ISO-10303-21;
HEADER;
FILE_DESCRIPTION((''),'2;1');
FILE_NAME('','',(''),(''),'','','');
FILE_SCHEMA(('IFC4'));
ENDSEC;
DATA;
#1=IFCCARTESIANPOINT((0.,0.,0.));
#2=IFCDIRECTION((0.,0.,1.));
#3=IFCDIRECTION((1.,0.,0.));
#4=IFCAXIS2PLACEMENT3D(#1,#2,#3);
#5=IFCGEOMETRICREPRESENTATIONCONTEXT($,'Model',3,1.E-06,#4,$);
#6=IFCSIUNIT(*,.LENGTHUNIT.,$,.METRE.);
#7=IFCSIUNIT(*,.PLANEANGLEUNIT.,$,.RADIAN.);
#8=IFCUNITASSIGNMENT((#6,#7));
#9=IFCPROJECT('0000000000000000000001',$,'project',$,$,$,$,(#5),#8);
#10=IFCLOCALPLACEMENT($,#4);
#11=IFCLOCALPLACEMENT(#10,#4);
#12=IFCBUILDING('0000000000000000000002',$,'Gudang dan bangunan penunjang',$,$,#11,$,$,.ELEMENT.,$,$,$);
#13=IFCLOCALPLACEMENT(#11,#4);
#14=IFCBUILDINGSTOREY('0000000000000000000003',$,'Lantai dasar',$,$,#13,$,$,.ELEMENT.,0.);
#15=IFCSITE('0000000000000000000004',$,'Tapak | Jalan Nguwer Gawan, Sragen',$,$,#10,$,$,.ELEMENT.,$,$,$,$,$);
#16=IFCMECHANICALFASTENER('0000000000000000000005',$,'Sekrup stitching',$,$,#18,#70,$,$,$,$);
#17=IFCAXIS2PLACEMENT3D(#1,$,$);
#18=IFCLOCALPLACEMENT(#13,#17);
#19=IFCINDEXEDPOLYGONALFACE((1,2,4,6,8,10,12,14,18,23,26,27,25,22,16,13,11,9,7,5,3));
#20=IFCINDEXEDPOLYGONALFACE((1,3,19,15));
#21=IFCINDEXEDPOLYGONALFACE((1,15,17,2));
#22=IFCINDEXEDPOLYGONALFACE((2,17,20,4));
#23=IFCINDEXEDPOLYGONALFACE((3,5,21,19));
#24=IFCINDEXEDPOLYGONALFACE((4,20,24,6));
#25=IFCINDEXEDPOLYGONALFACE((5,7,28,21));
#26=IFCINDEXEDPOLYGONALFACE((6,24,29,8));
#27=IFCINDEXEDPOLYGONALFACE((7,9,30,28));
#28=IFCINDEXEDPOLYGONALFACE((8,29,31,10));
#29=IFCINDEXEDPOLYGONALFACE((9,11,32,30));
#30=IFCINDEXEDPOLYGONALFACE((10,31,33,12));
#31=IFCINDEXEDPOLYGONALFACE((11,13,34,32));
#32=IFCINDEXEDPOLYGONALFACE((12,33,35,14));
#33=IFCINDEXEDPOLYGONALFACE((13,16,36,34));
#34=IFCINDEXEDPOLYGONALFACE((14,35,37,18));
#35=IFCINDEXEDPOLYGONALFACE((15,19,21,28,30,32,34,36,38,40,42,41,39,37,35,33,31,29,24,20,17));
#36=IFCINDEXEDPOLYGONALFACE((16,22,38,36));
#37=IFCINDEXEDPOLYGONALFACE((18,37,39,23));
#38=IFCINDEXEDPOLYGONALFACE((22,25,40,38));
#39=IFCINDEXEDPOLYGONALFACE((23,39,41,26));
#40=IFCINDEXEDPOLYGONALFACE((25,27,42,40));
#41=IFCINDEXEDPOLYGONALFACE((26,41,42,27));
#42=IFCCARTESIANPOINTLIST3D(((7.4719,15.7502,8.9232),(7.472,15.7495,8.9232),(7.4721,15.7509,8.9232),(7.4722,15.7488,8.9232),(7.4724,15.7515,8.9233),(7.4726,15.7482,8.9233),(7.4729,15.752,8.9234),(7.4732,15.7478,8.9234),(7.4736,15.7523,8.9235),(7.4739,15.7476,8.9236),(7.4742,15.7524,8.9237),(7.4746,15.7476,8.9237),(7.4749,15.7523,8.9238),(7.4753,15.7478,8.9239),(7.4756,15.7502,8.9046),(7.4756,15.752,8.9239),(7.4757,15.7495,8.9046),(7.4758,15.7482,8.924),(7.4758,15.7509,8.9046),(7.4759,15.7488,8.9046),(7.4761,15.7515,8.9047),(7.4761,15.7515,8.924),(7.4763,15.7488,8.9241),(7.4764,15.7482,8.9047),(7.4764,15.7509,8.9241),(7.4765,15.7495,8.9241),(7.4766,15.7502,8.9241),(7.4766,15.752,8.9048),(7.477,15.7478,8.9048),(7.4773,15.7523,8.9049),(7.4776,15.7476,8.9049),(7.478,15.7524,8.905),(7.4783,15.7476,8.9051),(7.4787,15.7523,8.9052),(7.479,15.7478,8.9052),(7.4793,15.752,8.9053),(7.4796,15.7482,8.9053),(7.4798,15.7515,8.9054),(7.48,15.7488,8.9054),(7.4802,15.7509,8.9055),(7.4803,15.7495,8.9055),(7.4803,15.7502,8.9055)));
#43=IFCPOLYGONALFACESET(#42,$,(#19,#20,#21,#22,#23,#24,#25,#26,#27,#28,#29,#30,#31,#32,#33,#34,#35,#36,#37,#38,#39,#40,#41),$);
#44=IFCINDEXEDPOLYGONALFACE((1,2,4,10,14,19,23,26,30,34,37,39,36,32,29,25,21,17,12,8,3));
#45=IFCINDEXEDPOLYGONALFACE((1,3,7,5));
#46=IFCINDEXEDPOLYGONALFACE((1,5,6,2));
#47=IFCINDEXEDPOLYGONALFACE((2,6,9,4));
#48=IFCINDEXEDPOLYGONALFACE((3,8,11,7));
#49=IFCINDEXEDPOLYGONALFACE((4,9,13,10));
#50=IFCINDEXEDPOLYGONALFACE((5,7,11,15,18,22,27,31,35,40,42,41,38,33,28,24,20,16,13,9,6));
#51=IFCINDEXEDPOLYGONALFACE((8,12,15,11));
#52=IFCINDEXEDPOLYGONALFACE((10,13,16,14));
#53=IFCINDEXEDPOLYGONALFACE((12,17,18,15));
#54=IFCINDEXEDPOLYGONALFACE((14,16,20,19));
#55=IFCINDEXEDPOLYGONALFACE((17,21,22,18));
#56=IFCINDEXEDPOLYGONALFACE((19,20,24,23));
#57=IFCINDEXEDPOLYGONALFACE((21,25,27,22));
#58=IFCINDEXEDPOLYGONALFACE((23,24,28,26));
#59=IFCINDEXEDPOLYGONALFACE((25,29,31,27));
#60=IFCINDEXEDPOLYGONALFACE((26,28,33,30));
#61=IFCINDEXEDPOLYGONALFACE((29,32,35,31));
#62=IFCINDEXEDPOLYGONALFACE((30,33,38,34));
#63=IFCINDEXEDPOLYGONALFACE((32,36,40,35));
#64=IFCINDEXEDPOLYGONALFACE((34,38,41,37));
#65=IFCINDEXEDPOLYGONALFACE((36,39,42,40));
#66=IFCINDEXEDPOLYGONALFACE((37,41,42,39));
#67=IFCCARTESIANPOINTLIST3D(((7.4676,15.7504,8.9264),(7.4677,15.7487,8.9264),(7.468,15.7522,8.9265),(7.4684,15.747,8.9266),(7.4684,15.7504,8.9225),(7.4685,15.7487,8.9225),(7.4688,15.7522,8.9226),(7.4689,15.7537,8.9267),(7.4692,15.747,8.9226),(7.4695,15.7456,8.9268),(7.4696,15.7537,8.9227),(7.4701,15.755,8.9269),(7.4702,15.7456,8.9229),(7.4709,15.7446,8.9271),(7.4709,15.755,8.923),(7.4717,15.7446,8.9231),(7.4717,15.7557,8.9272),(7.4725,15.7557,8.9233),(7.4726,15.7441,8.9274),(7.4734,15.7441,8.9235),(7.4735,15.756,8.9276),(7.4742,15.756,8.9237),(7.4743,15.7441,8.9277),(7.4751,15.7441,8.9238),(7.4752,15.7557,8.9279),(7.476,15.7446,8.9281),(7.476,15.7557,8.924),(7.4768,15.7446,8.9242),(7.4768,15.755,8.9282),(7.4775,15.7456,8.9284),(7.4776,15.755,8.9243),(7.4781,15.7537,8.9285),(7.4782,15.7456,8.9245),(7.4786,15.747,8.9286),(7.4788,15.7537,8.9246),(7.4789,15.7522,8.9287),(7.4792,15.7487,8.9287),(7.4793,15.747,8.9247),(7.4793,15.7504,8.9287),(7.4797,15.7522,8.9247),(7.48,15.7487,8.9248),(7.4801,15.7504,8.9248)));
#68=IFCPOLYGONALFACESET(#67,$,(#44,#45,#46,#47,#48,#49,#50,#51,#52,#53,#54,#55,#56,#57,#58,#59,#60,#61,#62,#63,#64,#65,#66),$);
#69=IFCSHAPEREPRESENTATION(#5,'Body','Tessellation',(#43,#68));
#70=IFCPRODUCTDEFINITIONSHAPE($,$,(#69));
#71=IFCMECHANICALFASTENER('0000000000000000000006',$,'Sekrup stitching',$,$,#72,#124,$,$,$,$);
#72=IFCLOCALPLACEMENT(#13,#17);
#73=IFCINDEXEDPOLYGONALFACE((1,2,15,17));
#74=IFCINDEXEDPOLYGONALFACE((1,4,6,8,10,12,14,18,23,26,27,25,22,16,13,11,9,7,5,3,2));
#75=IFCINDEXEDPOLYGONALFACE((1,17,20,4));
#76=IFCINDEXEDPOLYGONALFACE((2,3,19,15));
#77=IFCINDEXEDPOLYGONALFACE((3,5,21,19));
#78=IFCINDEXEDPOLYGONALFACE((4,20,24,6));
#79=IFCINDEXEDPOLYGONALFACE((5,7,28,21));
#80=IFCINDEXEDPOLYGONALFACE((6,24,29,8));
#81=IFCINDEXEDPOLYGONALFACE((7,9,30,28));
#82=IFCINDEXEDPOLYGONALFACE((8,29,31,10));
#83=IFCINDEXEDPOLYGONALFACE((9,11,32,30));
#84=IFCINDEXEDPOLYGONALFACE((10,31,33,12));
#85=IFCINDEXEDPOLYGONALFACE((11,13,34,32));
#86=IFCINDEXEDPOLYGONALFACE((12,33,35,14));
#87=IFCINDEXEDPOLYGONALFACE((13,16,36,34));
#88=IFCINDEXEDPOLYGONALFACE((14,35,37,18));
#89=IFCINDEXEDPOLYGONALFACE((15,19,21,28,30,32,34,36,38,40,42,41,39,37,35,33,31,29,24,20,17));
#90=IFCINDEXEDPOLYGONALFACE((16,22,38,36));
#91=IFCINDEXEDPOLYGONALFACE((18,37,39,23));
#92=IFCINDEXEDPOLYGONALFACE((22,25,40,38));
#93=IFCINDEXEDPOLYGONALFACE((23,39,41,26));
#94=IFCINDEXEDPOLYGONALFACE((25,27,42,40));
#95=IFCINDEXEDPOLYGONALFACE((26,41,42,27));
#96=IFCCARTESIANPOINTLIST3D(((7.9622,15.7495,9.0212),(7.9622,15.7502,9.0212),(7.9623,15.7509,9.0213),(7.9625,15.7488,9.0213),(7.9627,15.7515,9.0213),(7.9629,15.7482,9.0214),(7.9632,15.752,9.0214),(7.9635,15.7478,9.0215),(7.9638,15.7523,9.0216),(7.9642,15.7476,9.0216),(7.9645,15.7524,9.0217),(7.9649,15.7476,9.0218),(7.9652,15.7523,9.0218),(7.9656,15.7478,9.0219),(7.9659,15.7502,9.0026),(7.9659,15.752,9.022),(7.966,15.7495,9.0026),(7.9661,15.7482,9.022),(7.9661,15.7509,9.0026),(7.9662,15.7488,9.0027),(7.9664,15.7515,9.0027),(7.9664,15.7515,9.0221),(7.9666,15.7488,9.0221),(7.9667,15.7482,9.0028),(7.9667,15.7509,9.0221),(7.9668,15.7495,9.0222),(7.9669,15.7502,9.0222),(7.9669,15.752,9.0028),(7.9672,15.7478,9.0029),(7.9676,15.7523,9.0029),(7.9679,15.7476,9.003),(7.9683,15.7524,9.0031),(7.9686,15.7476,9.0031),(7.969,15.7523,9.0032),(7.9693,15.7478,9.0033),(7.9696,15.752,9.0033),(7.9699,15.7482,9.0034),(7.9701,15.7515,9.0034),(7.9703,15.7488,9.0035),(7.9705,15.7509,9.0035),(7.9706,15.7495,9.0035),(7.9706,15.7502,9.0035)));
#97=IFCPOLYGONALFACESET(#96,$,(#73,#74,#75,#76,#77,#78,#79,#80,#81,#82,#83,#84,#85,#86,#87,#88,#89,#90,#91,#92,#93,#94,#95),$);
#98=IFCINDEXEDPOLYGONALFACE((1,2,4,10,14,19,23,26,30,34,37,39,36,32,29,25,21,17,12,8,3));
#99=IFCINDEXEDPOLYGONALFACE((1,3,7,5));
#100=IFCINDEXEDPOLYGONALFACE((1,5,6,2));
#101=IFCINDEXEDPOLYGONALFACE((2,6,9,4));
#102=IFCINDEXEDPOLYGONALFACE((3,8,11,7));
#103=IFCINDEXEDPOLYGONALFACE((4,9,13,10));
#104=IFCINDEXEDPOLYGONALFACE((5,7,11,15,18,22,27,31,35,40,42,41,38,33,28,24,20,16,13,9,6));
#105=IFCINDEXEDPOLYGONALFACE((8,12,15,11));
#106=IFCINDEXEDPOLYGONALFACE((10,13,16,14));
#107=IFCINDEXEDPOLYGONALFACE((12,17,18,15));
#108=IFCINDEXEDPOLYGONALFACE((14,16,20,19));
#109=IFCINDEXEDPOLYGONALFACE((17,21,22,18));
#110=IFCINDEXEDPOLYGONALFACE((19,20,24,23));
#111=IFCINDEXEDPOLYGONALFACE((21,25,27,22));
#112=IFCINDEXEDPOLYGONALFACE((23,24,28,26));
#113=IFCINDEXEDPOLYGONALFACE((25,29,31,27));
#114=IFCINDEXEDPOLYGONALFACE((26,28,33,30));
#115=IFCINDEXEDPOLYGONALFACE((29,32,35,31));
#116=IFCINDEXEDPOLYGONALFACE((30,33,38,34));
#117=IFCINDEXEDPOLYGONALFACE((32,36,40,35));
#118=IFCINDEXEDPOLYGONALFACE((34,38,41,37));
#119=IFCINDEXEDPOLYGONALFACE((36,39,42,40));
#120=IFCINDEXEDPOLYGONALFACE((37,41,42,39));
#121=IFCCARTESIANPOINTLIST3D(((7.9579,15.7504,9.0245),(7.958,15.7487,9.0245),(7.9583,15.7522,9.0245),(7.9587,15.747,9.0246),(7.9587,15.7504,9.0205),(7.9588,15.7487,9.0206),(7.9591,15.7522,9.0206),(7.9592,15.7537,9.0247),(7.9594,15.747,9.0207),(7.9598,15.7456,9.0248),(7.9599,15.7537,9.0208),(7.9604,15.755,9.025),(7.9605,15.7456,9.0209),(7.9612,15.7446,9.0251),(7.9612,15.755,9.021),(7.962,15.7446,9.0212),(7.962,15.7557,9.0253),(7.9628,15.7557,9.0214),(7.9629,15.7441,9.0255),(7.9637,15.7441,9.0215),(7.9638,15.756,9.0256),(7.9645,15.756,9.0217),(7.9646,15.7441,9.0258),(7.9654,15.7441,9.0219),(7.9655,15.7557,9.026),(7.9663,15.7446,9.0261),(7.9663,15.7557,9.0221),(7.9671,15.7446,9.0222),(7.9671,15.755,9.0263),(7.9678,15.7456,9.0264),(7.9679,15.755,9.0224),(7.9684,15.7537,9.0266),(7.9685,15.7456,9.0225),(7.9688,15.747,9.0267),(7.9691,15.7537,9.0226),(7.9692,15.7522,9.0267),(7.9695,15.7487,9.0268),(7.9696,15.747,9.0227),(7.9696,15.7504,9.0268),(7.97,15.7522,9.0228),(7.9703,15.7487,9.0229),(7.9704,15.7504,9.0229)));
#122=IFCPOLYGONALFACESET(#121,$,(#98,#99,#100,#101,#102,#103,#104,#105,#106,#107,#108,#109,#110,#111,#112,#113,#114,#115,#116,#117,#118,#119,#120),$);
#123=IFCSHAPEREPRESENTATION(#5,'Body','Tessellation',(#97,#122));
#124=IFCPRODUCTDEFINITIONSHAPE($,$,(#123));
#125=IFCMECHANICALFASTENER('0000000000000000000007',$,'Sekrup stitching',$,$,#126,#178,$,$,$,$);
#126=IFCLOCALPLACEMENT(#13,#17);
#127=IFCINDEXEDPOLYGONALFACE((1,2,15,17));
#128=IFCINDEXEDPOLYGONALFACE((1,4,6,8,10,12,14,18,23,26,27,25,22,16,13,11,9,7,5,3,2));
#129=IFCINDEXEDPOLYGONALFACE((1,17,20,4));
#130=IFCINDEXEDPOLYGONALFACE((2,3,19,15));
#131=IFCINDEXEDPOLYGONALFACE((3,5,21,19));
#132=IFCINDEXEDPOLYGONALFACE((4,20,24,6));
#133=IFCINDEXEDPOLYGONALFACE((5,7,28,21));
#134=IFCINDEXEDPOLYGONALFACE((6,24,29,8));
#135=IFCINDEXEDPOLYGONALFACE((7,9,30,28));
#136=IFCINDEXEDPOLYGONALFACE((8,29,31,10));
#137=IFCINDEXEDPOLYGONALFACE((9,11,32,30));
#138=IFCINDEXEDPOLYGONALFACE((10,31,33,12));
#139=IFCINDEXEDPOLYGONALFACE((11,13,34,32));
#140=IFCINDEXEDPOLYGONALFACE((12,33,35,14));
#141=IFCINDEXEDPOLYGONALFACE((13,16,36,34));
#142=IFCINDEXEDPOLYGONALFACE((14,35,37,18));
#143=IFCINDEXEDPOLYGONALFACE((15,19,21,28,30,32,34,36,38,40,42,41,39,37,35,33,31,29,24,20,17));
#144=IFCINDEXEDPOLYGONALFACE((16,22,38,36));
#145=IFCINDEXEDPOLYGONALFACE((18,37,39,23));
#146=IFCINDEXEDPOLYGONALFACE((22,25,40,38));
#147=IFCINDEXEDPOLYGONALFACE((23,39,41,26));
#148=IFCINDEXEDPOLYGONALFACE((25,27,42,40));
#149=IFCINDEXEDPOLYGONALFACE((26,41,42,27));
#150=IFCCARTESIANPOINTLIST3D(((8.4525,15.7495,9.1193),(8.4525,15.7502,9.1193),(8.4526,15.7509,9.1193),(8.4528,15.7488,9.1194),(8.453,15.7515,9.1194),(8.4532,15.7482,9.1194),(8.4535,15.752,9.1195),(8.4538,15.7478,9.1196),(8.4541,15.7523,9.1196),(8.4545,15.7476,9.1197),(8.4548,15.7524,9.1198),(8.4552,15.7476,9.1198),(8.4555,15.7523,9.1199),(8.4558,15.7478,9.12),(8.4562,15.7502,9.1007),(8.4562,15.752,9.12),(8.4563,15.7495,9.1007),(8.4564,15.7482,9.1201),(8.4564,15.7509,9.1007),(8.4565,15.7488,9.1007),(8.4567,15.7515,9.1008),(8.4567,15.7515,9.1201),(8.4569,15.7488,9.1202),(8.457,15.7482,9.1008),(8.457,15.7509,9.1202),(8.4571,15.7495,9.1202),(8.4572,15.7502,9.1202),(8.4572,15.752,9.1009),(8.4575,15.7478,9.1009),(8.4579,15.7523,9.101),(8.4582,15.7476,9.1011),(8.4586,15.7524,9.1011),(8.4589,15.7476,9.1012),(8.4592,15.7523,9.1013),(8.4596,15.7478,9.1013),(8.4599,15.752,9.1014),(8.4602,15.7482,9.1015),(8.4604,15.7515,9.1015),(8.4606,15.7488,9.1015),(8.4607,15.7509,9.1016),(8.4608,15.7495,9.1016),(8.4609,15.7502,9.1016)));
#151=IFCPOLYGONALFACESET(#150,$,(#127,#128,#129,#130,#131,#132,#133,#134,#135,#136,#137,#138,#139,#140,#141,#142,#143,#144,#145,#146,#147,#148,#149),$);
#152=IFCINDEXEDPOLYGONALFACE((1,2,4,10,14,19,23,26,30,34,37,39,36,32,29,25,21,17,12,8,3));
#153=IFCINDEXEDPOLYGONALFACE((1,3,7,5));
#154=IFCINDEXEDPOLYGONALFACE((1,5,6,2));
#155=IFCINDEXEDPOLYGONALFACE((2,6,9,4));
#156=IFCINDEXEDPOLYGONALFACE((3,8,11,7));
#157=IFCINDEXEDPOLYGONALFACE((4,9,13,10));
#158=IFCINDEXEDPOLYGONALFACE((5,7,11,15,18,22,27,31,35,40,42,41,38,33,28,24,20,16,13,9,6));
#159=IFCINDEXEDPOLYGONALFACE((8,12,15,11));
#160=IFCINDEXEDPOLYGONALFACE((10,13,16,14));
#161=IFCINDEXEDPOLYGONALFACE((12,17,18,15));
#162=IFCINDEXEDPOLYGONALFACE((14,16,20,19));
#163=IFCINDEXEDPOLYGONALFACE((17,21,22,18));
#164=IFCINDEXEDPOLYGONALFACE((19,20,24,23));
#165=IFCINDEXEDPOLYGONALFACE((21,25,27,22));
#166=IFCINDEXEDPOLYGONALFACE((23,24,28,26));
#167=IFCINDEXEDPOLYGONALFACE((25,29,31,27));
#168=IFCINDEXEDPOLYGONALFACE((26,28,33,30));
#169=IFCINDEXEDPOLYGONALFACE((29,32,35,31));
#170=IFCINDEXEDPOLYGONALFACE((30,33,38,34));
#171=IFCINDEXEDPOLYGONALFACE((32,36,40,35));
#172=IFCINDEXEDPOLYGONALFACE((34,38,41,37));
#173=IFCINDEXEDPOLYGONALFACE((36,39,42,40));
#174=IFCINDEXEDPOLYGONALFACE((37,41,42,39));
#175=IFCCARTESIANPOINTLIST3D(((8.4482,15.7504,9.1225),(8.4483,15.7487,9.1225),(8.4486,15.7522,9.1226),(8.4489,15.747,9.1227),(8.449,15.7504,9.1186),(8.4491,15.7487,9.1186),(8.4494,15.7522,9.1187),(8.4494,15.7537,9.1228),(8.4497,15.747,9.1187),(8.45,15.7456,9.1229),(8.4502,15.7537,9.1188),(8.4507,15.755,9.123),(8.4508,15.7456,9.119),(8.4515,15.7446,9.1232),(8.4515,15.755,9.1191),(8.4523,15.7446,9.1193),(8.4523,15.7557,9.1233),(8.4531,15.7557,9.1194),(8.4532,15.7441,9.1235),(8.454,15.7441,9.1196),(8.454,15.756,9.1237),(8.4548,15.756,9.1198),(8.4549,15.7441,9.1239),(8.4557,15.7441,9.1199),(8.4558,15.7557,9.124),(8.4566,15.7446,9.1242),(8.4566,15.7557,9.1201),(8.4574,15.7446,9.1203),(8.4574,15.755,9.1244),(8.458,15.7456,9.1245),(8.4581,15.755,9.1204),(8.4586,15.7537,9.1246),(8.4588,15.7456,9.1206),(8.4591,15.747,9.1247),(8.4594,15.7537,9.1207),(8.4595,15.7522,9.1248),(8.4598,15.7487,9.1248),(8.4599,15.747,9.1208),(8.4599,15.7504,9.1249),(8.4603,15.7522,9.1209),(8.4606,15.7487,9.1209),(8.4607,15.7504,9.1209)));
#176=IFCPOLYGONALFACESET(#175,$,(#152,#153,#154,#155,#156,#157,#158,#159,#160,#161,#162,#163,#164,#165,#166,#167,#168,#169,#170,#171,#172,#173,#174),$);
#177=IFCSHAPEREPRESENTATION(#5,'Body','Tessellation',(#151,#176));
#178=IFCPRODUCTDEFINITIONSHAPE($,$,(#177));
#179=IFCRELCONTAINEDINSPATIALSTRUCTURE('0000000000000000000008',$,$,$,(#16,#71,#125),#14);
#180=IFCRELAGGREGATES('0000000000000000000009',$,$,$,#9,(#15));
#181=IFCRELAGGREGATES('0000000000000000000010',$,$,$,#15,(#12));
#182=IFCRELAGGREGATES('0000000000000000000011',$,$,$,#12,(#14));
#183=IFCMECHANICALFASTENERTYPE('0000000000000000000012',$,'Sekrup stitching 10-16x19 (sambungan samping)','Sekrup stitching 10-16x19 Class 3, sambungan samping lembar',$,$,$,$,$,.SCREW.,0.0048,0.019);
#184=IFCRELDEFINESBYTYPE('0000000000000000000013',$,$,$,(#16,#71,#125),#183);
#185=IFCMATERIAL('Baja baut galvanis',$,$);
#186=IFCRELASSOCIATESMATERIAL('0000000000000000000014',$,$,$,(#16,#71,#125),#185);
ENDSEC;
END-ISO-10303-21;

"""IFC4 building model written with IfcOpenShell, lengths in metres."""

from ifc_helpers import new_model, si_unit, frame, origin_with_axes, place, context, project, spatial, circle, extrude, source, transform, mapped, material, type_object, type_shapes, element, save


model = new_model("IFC4")

# Units and contexts
model_context = context("Model", 3, precision=1e-06, world=origin_with_axes())
ifc_project = project(units=[si_unit("LENGTHUNIT", "METRE"), si_unit("PLANEANGLEUNIT", "RADIAN")], contexts=[model_context])

# Site, building, storey
site_placement = place(None, origin_with_axes())
site = spatial("IfcSite", under=ifc_project, at=site_placement, Name="Tapak | Jalan Nguwer Gawan, Sragen", CompositionType="ELEMENT")
building_placement = place(site_placement, origin_with_axes())
building = spatial("IfcBuilding", under=site, at=building_placement, Name="Gudang dan bangunan penunjang", CompositionType="ELEMENT")
storey_placement = place(building_placement, origin_with_axes())
storey = spatial("IfcBuildingStorey", under=building, at=storey_placement, Name="Lantai dasar", CompositionType="ELEMENT", Elevation=0.0)

# Shared definitions
placement = place(None, origin_with_axes())

# Mechanical fasteners
ifc_material_1 = material(Name="Baja baut galvanis")
mechanical_fastener_type_1 = type_object("IfcMechanicalFastenerType", Name="Sekrup stitching 10-16x19 (sambungan samping)", Description="Sekrup stitching 10-16x19 Class 3, sambungan samping lembar", NominalDiameter=0.0048, NominalLength=0.019, PredefinedType="SCREW")
shared_shape_1 = source(origin_with_axes(), model_context, "Body", "SweptSolid", [
    extrude(circle(Radius=0.0024), origin_with_axes(), (0.0, 0.0, 1.0), 0.019),
    extrude(circle(Radius=0.006), frame((0.0, 0.0, -0.004), z_axis=(0.0, 0.0, 1.0), x_axis=(1.0, 0.0, 0.0)), (0.0, 0.0, 1.0), 0.004),
])
type_shapes(mechanical_fastener_type_1, [shared_shape_1])
element("IfcMechanicalFastener", 1, at=placement, inside=storey, type_object=mechanical_fastener_type_1, material=ifc_material_1, Name="Sekrup stitching", context=model_context, shape_type="MappedRepresentation", body=[
    mapped(shared_shape_1, transform((7.4742, 15.75, 8.9237), x_axis=(0.0, 1.0, 0.0), y_axis=(0.980581, 0.0, 0.196116), z_axis=(0.196116, 0.0, -0.980581), scale=1.0)),
])
element("IfcMechanicalFastener", 2, at=placement, inside=storey, type_object=mechanical_fastener_type_1, material=ifc_material_1, Name="Sekrup stitching", context=model_context, shape_type="MappedRepresentation", body=[
    mapped(shared_shape_1, transform((7.9645, 15.75, 9.0217), x_axis=(0.0, 1.0, 0.0), y_axis=(0.980581, 0.0, 0.196116), z_axis=(0.196116, 0.0, -0.980581), scale=1.0)),
])
element("IfcMechanicalFastener", 3, at=placement, inside=storey, type_object=mechanical_fastener_type_1, material=ifc_material_1, Name="Sekrup stitching", context=model_context, shape_type="MappedRepresentation", body=[
    mapped(shared_shape_1, transform((8.4548, 15.75, 9.1198), x_axis=(0.0, 1.0, 0.0), y_axis=(0.980581, 0.0, 0.196116), z_axis=(0.196116, 0.0, -0.980581), scale=1.0)),
])

save(model, "model.ifc")
